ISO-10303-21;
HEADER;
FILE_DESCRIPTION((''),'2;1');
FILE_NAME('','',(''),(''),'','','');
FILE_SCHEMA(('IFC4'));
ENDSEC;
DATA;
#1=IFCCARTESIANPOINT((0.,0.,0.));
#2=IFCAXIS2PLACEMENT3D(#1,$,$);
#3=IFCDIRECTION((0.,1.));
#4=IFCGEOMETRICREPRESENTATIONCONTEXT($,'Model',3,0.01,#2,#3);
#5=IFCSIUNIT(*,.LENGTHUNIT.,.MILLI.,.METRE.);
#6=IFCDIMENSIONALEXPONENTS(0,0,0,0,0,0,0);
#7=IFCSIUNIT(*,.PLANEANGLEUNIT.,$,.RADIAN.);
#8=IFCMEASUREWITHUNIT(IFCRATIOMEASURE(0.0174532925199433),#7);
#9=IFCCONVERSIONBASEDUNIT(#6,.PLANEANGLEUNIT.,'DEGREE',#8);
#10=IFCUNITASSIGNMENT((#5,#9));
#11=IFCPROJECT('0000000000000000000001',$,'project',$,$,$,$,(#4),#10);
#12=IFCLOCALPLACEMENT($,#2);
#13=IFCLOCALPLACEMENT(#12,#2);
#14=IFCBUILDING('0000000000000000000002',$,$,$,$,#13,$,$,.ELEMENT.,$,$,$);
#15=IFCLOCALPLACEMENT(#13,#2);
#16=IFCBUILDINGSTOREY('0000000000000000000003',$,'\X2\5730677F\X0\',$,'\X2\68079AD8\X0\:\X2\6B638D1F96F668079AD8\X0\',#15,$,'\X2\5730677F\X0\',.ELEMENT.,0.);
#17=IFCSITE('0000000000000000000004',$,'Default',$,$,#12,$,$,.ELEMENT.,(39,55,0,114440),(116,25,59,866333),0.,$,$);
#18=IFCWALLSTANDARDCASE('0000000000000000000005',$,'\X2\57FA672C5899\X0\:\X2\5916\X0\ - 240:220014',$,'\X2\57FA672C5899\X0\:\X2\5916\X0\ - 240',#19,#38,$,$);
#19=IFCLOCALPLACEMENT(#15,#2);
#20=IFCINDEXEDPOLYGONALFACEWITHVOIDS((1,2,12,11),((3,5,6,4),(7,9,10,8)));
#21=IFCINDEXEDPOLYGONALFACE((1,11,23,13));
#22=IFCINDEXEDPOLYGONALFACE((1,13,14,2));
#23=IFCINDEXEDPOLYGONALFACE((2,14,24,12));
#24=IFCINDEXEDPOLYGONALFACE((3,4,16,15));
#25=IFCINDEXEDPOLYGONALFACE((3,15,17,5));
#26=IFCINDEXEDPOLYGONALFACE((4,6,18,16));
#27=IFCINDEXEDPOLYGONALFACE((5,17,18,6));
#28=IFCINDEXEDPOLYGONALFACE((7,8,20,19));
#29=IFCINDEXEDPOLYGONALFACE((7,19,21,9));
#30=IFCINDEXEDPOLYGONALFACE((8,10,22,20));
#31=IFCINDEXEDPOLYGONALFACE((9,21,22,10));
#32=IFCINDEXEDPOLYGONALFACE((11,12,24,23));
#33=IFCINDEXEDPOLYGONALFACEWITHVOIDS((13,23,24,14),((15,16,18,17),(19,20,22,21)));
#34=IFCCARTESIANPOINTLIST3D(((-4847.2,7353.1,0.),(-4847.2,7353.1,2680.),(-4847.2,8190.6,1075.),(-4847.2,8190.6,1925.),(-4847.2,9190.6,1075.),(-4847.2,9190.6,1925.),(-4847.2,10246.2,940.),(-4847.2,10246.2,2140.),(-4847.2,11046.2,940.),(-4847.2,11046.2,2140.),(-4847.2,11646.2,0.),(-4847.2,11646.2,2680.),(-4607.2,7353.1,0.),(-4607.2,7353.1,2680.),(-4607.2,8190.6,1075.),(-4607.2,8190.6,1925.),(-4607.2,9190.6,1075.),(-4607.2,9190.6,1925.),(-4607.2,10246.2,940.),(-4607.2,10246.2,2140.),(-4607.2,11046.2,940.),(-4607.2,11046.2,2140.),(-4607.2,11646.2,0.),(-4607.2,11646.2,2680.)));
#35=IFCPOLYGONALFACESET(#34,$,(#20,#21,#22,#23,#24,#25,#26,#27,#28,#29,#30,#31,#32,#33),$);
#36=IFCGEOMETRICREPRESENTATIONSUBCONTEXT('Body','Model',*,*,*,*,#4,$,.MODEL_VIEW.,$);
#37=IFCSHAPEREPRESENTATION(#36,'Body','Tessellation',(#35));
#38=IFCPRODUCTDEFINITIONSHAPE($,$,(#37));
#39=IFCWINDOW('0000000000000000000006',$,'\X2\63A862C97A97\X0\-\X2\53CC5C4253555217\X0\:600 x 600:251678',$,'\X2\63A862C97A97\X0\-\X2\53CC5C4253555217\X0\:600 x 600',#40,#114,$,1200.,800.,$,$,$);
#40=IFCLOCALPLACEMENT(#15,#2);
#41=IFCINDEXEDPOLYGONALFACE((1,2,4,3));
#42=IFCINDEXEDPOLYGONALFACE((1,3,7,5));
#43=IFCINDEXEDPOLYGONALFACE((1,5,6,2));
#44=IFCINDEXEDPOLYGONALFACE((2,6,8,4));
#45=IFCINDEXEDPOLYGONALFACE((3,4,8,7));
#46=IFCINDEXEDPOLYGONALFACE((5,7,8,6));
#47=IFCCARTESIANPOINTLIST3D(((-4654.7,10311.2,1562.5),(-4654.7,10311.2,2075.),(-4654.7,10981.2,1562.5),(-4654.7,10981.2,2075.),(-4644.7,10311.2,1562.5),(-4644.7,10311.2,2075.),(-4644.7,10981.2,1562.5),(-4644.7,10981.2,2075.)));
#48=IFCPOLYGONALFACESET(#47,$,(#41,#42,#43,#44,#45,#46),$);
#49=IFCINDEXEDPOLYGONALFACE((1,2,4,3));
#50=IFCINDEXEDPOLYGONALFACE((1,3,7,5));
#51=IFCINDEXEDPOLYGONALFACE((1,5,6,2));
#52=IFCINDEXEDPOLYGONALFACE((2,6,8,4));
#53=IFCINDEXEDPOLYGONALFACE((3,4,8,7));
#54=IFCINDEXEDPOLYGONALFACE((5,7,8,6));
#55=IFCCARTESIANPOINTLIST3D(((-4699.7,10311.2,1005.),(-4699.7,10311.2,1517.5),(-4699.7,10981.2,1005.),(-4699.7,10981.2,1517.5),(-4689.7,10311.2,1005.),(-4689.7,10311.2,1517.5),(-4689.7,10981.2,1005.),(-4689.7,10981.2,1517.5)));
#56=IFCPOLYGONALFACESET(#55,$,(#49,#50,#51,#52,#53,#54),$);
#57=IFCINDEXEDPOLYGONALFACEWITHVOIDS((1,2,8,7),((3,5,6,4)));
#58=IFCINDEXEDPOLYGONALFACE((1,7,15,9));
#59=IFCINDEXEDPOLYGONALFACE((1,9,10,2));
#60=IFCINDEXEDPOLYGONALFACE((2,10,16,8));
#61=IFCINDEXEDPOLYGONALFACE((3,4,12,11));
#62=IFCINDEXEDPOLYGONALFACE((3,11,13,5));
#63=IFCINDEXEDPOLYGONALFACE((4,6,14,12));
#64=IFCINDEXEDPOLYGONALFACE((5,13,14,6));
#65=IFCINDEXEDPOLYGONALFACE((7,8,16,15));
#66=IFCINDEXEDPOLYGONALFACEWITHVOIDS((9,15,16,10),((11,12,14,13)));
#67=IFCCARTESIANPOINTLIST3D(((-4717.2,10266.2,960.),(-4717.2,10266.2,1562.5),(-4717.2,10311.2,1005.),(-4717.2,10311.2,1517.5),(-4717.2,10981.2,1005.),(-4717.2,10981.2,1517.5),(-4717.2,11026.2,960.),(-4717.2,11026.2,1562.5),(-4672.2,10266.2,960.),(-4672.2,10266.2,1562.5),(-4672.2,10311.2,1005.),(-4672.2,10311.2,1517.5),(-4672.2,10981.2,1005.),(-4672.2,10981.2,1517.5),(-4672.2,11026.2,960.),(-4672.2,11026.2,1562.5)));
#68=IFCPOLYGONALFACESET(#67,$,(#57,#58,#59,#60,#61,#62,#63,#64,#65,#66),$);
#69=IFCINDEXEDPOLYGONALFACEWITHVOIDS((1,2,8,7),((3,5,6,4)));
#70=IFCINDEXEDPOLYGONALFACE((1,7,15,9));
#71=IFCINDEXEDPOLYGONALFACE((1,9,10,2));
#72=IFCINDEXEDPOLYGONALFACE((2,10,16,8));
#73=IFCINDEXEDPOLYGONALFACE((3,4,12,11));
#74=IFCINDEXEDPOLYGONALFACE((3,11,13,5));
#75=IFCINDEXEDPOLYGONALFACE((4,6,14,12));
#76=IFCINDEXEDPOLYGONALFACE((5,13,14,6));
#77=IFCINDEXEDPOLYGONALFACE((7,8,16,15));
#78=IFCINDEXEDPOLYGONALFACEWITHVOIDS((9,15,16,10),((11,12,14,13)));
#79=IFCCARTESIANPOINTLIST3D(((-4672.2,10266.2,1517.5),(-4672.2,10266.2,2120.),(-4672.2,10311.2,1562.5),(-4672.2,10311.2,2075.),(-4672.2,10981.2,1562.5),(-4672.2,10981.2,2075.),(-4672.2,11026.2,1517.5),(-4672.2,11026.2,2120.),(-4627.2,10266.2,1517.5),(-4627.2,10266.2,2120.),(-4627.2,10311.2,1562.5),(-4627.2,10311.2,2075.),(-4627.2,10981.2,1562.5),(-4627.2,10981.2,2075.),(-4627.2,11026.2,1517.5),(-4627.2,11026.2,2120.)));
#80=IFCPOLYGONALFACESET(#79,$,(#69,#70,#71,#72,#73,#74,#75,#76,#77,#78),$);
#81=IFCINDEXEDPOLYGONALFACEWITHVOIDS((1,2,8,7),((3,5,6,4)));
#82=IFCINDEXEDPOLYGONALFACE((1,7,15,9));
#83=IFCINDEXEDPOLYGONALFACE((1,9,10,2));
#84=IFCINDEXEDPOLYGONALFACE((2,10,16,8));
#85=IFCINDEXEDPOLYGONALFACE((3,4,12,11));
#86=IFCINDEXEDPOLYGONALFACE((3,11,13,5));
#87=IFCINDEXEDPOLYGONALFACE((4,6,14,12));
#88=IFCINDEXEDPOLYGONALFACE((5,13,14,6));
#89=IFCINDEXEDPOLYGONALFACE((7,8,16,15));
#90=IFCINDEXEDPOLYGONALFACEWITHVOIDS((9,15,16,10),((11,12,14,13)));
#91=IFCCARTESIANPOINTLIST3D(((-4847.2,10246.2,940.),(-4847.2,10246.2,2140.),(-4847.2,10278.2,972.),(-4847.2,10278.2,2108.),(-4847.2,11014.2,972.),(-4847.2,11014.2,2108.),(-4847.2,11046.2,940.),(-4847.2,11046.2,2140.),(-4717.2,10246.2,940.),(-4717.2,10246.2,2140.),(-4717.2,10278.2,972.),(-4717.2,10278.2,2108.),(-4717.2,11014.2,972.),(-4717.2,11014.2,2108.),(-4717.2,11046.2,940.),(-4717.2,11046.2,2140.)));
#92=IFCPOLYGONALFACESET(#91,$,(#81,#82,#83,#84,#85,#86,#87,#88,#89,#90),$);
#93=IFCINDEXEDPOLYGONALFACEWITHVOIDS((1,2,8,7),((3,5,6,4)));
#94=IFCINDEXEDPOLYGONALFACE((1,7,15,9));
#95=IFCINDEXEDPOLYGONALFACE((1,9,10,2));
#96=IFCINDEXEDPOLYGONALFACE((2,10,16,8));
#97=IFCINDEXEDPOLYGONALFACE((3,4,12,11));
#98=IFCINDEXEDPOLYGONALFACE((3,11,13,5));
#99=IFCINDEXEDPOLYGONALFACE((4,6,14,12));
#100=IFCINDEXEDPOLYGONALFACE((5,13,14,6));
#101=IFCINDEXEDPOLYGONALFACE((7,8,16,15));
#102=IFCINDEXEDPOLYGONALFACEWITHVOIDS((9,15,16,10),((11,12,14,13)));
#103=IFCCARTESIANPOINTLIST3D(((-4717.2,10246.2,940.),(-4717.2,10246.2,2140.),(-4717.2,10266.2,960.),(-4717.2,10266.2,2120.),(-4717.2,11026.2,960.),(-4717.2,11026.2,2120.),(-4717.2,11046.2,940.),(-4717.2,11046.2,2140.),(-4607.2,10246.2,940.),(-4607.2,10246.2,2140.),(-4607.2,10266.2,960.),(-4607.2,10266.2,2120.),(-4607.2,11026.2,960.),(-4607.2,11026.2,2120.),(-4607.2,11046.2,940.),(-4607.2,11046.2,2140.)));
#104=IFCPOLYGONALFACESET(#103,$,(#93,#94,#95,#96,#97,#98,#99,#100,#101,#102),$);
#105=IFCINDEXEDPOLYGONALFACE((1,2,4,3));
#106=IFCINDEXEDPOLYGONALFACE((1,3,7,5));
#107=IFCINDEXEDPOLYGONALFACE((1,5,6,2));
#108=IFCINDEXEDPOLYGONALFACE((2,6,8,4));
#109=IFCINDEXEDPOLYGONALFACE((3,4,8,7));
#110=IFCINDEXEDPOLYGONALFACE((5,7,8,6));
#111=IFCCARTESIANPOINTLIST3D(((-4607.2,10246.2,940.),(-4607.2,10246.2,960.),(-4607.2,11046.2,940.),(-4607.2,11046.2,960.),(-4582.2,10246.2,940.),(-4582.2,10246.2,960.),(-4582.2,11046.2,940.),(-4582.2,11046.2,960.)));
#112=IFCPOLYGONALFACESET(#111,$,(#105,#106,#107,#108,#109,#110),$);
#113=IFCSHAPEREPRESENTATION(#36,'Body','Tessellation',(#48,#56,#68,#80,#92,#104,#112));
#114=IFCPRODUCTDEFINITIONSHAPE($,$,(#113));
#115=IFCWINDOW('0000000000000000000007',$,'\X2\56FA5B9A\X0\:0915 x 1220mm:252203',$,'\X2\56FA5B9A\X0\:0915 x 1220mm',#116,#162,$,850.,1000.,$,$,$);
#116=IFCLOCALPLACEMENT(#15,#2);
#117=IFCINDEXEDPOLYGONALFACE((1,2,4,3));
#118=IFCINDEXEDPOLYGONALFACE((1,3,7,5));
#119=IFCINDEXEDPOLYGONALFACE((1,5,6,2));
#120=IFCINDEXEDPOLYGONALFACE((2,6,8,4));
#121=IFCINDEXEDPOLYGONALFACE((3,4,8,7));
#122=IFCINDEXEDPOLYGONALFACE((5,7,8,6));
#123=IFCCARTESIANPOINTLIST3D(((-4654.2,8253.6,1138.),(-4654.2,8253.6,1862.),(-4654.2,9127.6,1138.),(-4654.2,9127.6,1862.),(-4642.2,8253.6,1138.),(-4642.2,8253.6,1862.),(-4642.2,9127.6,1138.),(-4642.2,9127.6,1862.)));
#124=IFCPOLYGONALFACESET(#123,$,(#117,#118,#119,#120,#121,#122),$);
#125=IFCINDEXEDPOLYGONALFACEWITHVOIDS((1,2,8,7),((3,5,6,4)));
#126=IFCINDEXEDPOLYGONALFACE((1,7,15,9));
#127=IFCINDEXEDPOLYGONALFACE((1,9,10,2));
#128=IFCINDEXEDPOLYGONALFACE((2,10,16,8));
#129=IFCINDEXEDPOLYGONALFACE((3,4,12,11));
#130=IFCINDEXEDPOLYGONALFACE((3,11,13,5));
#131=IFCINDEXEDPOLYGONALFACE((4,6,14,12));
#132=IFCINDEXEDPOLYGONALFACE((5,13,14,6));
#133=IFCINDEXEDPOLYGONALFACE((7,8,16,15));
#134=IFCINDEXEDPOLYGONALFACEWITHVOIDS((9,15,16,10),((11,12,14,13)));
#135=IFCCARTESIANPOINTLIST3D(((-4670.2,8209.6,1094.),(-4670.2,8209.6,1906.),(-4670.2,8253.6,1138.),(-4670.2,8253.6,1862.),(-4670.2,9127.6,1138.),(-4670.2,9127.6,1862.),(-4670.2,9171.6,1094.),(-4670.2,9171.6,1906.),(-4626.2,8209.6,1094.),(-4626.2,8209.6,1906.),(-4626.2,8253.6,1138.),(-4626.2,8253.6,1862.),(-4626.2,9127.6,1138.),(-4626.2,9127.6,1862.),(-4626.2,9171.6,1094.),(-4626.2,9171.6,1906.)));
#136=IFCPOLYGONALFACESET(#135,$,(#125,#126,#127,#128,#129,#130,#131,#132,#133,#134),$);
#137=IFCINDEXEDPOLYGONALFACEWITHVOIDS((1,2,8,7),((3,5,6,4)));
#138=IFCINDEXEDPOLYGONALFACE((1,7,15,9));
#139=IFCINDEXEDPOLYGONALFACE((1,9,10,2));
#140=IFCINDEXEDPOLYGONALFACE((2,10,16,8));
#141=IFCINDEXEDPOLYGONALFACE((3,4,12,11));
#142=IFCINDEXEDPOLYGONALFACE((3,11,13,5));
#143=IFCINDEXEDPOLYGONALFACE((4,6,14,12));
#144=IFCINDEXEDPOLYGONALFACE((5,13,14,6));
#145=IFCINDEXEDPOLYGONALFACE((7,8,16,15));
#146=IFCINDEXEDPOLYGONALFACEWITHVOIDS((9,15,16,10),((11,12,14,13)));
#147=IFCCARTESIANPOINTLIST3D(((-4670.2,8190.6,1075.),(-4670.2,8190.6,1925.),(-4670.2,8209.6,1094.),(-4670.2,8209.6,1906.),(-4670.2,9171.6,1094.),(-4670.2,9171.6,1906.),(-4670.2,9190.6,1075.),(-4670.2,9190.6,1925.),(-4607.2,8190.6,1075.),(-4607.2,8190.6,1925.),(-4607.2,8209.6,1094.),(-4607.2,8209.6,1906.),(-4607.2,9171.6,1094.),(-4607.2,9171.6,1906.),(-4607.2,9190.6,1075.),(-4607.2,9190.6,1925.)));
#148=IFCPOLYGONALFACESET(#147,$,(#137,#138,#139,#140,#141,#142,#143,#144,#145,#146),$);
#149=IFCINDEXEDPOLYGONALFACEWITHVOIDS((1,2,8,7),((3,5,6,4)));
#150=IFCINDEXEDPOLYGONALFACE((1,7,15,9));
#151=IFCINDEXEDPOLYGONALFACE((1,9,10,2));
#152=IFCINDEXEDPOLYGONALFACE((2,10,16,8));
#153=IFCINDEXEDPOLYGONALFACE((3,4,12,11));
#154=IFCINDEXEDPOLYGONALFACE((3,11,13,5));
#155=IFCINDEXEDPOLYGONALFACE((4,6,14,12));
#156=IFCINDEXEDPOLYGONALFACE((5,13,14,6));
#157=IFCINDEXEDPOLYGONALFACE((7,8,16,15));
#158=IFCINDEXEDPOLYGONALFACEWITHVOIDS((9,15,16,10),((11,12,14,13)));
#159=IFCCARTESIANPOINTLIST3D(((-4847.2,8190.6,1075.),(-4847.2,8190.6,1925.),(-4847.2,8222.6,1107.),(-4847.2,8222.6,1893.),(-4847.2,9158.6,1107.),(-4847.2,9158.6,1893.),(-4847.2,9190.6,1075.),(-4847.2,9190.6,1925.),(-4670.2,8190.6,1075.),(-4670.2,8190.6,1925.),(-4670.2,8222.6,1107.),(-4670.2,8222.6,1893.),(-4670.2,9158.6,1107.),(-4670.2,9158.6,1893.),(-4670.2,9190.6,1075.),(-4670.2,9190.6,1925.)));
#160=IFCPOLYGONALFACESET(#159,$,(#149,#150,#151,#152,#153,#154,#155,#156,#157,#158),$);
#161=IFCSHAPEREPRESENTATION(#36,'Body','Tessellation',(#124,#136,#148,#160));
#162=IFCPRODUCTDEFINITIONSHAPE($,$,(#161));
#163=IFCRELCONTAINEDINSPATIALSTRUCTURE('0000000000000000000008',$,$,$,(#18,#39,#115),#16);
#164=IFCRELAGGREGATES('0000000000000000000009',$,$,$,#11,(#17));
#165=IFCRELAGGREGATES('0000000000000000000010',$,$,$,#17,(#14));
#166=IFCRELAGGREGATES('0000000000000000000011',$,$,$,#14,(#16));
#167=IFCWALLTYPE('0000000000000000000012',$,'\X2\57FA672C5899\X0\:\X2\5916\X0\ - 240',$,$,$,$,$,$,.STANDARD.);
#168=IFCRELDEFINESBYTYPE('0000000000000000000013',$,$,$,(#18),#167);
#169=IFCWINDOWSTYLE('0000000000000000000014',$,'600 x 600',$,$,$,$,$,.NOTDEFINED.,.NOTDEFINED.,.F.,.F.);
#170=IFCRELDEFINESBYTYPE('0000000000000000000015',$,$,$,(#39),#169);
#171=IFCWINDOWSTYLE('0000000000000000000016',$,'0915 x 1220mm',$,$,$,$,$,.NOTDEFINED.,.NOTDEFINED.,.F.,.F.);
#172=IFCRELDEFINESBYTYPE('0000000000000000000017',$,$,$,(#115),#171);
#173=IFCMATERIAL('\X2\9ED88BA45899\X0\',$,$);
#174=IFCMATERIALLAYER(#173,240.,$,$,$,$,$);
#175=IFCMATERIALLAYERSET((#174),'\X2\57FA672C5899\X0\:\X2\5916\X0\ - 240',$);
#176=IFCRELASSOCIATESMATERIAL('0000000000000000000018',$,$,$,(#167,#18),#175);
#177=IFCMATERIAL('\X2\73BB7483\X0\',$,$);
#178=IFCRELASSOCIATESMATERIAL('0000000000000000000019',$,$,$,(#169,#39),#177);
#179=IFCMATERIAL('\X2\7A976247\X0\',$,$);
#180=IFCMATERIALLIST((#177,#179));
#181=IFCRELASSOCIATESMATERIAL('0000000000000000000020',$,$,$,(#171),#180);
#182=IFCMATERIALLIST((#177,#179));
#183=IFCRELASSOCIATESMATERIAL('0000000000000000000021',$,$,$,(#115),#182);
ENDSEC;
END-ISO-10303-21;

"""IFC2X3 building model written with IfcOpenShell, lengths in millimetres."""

from ifc_helpers import new_model, entity, si_unit, converted_unit, direction, frame, frame_2d, origin, origin_2d_with_axis, place, context, subcontext, project, spatial, polyline, rectangle, outline, extrude, source, transform, mapped, material, material_list, layer, layer_set, layer_usage, type_object, type_shapes, element, fill, save


model = new_model("IFC2X3")

# Units and contexts
model_context = context("Model", 3, precision=0.01, world=origin(), true_north=direction((0.0, 1.0)))
body_context = subcontext(model_context, "Body", "Model", "MODEL_VIEW")
ifc_project = project(units=[si_unit("LENGTHUNIT", "METRE", prefix="MILLI"), converted_unit("PLANEANGLEUNIT", "DEGREE", entity("IfcRatioMeasure", 0.0174532925199433), si_unit("PLANEANGLEUNIT", "RADIAN"), dimensions=[0, 0, 0, 0, 0, 0, 0])], contexts=[model_context])

# Site, building, storey
site_placement = place(None, origin())
site = spatial("IfcSite", under=ifc_project, at=site_placement, Name="Default", CompositionType="ELEMENT", RefLatitude=(39, 55, 0, 114440), RefLongitude=(116, 25, 59, 866333), RefElevation=0.0)
building_placement = place(site_placement, origin())
building = spatial("IfcBuilding", under=site, at=building_placement, CompositionType="ELEMENT")
storey_placement = place(building_placement, origin())
storey = spatial("IfcBuildingStorey", under=building, at=storey_placement, Name="地板", ObjectType="标高:正负零标高", LongName="地板", CompositionType="ELEMENT", Elevation=0.0)

# Wall, openings, windows
ifc_material_1 = material(Name="默认墙")
ifc_layer_1 = layer(ifc_material_1, 240.0)
ifc_layer_set_1 = layer_set([ifc_layer_1], Name="基本墙:外 - 240")
wall_type_1 = type_object("IfcWallType", Name="基本墙:外 - 240", PredefinedType="STANDARD", material=ifc_layer_set_1)
ifc_material_2 = material(Name="玻璃")
ifc_material_3 = material(Name="窗扇")
ifc_layer_usage_1 = layer_usage(ifc_layer_set_1, "AXIS2", "NEGATIVE", 120.0)
wall_1_placement = place(storey_placement, frame((-4727.2, 7353.1, 0.0), z_axis=(0.0, 0.0, 1.0), x_axis=(0.0, 1.0, 0.0)))
wall_1 = element("IfcWallStandardCase", 1, at=wall_1_placement, inside=storey, type_object=wall_type_1, material=ifc_layer_usage_1, Name="基本墙:外 - 240:220014", ObjectType="基本墙:外 - 240", context=body_context, shape_type="SweptSolid", body=[
    extrude(rectangle(XDim=4293.1, YDim=240.0, at=frame_2d((2146.5, 0.0), x_axis=(-1.0, 0.0))), origin(), (0.0, 0.0, 1.0), 2680.0),
])
opening_1_placement = place(wall_1_placement, frame((3693.1, 120.0, 940.0)))
opening_1 = element("IfcOpeningElement", 2, at=opening_1_placement, cuts=wall_1, ObjectType="Opening", context=body_context, shape_type="SweptSolid", body=[
    extrude(rectangle(XDim=1200.0, YDim=800.0, at=frame_2d((600.0, 400.0), x_axis=(-1.0, 0.0))), frame((0.0, 0.0, 0.0), z_axis=(0.0, -1.0, 0.0), x_axis=(0.0, 0.0, 1.0)), (0.0, 0.0, 1.0), 240.0),
])
opening_2_placement = place(wall_1_placement, frame((1837.5, 120.0, 1075.0)))
opening_2 = element("IfcOpeningElement", 3, at=opening_2_placement, cuts=wall_1, ObjectType="Opening", context=body_context, shape_type="SweptSolid", body=[
    extrude(rectangle(XDim=850.0, YDim=1000.0, at=frame_2d((425.0, 500.0), x_axis=(1.0, 0.0))), frame((0.0, 0.0, 0.0), z_axis=(0.0, -1.0, 0.0), x_axis=(0.0, 0.0, 1.0)), (0.0, 0.0, 1.0), 240.0),
])
window_style_1 = type_object("IfcWindowStyle", Name="600 x 600", ConstructionType="NOTDEFINED", OperationType="NOTDEFINED", ParameterTakesPrecedence=False, Sizeable=False, material=ifc_material_2)
shared_shape_1 = source(origin(), body_context, "Body", "SweptSolid", [
    extrude(rectangle(XDim=10.0, YDim=670.0, at=origin_2d_with_axis()), frame((400.0, 197.5, 622.5), z_axis=(0.0, 0.0, 1.0), x_axis=(0.0, -1.0, 0.0)), (0.0, 0.0, 1.0), 512.5),
    extrude(rectangle(XDim=10.0, YDim=670.0, at=origin_2d_with_axis()), frame((400.0, 152.5, 65.0), z_axis=(0.0, 0.0, 1.0), x_axis=(0.0, -1.0, 0.0)), (0.0, 0.0, 1.0), 512.5),
    extrude(outline(polyline([(-380.0, -301.2), (380.0, -301.2), (380.0, 301.2), (-380.0, 301.2), (-380.0, -301.2)]), holes=[polyline([(-335.0, -256.2), (-335.0, 256.2), (335.0, 256.2), (335.0, -256.2), (-335.0, -256.2)])]), frame((400.0, 130.0, 321.3), z_axis=(0.0, 1.0, 0.0), x_axis=(1.0, 0.0, 0.0)), (0.0, 0.0, 1.0), 45.0),
    extrude(outline(polyline([(-380.0, -301.2), (380.0, -301.2), (380.0, 301.2), (-380.0, 301.2), (-380.0, -301.2)]), holes=[polyline([(-335.0, -256.2), (-335.0, 256.2), (335.0, 256.2), (335.0, -256.2), (-335.0, -256.2)])]), frame((400.0, 175.0, 878.8), z_axis=(0.0, 1.0, 0.0), x_axis=(1.0, 0.0, 0.0)), (0.0, 0.0, 1.0), 45.0),
    extrude(outline(polyline([(-400.0, -600.0), (400.0, -600.0), (400.0, 600.0), (-400.0, 600.0), (-400.0, -600.0)]), holes=[polyline([(-368.0, -568.0), (-368.0, 568.0), (368.0, 568.0), (368.0, -568.0), (-368.0, -568.0)])]), frame((400.0, 0.0, 600.0), z_axis=(0.0, 1.0, 0.0), x_axis=(1.0, 0.0, 0.0)), (0.0, 0.0, 1.0), 130.0),
    extrude(outline(polyline([(-600.0, -400.0), (600.0, -400.0), (600.0, 400.0), (-600.0, 400.0), (-600.0, -400.0)]), holes=[polyline([(-580.0, -380.0), (-580.0, 380.0), (580.0, 380.0), (580.0, -380.0), (-580.0, -380.0)])]), frame((400.0, 130.0, 600.0), z_axis=(0.0, 1.0, 0.0), x_axis=(0.0, 0.0, -1.0)), (0.0, 0.0, 1.0), 110.0),
    extrude(rectangle(XDim=25.0, YDim=800.0, at=origin_2d_with_axis()), frame((400.0, 252.5, 0.0), z_axis=(0.0, 0.0, 1.0), x_axis=(0.0, -1.0, 0.0)), (0.0, 0.0, 1.0), 20.0),
])
type_shapes(window_style_1, [shared_shape_1])
window_1_placement = place(opening_1_placement, frame((0.0, 0.0, 0.0), z_axis=(0.0, 0.0, 1.0), x_axis=(-1.0, 0.0, 0.0)))
window_1 = element("IfcWindow", 4, at=window_1_placement, inside=storey, type_object=window_style_1, material=ifc_material_2, Name="推拉窗-双层单列:600 x 600:251678", ObjectType="推拉窗-双层单列:600 x 600", OverallHeight=1200.0, OverallWidth=800.0, context=body_context, shape_type="MappedRepresentation", body=[
    mapped(shared_shape_1, transform((0.0, 0.0, 0.0), scale=1.0)),
])
fill(opening_1, window_1)
ifc_material_list_1 = material_list([ifc_material_2, ifc_material_3])
ifc_material_list_2 = material_list([ifc_material_2, ifc_material_3])
window_style_2 = type_object("IfcWindowStyle", Name="0915 x 1220mm", ConstructionType="NOTDEFINED", OperationType="NOTDEFINED", ParameterTakesPrecedence=False, Sizeable=False, material=ifc_material_list_2)
shared_shape_2 = source(origin(), body_context, "Body", "SweptSolid", [
    extrude(rectangle(XDim=12.0, YDim=874.0, at=frame_2d((0.0, 0.0), x_axis=(1.0, 0.0))), frame((500.0, 199.0, 63.0), z_axis=(0.0, 0.0, 1.0), x_axis=(0.0, -1.0, 0.0)), (0.0, 0.0, 1.0), 724.0),
    extrude(outline(polyline([(-481.0, -406.0), (481.0, -406.0), (481.0, 406.0), (-481.0, 406.0), (-481.0, -406.0)]), holes=[polyline([(-437.0, -362.0), (-437.0, 362.0), (437.0, 362.0), (437.0, -362.0), (-437.0, -362.0)])]), frame((500.0, 177.0, 425.0), z_axis=(0.0, 1.0, 0.0), x_axis=(1.0, 0.0, 0.0)), (0.0, 0.0, 1.0), 44.0),
    extrude(outline(polyline([(-500.0, -425.0), (500.0, -425.0), (500.0, 425.0), (-500.0, 425.0), (-500.0, -425.0)]), holes=[polyline([(-481.0, -406.0), (-481.0, 406.0), (481.0, 406.0), (481.0, -406.0), (-481.0, -406.0)])]), frame((500.0, 177.0, 425.0), z_axis=(0.0, 1.0, 0.0), x_axis=(1.0, 0.0, 0.0)), (0.0, 0.0, 1.0), 63.0),
    extrude(outline(polyline([(-500.0, -425.0), (500.0, -425.0), (500.0, 425.0), (-500.0, 425.0), (-500.0, -425.0)]), holes=[polyline([(-468.0, -393.0), (-468.0, 393.0), (468.0, 393.0), (468.0, -393.0), (-468.0, -393.0)])]), frame((500.0, 0.0, 425.0), z_axis=(0.0, 1.0, 0.0), x_axis=(1.0, 0.0, 0.0)), (0.0, 0.0, 1.0), 177.0),
])
type_shapes(window_style_2, [shared_shape_2])
window_2_placement = place(opening_2_placement, frame((0.0, 0.0, 0.0), z_axis=(0.0, 0.0, 1.0), x_axis=(-1.0, 0.0, 0.0)))
window_2 = element("IfcWindow", 5, at=window_2_placement, inside=storey, type_object=window_style_2, material=ifc_material_list_1, Name="固定:0915 x 1220mm:252203", ObjectType="固定:0915 x 1220mm", OverallHeight=850.0, OverallWidth=1000.0, context=body_context, shape_type="MappedRepresentation", body=[
    mapped(shared_shape_2, transform((0.0, 0.0, 0.0), scale=1.0)),
])
fill(opening_2, window_2)

save(model, "model.ifc")
